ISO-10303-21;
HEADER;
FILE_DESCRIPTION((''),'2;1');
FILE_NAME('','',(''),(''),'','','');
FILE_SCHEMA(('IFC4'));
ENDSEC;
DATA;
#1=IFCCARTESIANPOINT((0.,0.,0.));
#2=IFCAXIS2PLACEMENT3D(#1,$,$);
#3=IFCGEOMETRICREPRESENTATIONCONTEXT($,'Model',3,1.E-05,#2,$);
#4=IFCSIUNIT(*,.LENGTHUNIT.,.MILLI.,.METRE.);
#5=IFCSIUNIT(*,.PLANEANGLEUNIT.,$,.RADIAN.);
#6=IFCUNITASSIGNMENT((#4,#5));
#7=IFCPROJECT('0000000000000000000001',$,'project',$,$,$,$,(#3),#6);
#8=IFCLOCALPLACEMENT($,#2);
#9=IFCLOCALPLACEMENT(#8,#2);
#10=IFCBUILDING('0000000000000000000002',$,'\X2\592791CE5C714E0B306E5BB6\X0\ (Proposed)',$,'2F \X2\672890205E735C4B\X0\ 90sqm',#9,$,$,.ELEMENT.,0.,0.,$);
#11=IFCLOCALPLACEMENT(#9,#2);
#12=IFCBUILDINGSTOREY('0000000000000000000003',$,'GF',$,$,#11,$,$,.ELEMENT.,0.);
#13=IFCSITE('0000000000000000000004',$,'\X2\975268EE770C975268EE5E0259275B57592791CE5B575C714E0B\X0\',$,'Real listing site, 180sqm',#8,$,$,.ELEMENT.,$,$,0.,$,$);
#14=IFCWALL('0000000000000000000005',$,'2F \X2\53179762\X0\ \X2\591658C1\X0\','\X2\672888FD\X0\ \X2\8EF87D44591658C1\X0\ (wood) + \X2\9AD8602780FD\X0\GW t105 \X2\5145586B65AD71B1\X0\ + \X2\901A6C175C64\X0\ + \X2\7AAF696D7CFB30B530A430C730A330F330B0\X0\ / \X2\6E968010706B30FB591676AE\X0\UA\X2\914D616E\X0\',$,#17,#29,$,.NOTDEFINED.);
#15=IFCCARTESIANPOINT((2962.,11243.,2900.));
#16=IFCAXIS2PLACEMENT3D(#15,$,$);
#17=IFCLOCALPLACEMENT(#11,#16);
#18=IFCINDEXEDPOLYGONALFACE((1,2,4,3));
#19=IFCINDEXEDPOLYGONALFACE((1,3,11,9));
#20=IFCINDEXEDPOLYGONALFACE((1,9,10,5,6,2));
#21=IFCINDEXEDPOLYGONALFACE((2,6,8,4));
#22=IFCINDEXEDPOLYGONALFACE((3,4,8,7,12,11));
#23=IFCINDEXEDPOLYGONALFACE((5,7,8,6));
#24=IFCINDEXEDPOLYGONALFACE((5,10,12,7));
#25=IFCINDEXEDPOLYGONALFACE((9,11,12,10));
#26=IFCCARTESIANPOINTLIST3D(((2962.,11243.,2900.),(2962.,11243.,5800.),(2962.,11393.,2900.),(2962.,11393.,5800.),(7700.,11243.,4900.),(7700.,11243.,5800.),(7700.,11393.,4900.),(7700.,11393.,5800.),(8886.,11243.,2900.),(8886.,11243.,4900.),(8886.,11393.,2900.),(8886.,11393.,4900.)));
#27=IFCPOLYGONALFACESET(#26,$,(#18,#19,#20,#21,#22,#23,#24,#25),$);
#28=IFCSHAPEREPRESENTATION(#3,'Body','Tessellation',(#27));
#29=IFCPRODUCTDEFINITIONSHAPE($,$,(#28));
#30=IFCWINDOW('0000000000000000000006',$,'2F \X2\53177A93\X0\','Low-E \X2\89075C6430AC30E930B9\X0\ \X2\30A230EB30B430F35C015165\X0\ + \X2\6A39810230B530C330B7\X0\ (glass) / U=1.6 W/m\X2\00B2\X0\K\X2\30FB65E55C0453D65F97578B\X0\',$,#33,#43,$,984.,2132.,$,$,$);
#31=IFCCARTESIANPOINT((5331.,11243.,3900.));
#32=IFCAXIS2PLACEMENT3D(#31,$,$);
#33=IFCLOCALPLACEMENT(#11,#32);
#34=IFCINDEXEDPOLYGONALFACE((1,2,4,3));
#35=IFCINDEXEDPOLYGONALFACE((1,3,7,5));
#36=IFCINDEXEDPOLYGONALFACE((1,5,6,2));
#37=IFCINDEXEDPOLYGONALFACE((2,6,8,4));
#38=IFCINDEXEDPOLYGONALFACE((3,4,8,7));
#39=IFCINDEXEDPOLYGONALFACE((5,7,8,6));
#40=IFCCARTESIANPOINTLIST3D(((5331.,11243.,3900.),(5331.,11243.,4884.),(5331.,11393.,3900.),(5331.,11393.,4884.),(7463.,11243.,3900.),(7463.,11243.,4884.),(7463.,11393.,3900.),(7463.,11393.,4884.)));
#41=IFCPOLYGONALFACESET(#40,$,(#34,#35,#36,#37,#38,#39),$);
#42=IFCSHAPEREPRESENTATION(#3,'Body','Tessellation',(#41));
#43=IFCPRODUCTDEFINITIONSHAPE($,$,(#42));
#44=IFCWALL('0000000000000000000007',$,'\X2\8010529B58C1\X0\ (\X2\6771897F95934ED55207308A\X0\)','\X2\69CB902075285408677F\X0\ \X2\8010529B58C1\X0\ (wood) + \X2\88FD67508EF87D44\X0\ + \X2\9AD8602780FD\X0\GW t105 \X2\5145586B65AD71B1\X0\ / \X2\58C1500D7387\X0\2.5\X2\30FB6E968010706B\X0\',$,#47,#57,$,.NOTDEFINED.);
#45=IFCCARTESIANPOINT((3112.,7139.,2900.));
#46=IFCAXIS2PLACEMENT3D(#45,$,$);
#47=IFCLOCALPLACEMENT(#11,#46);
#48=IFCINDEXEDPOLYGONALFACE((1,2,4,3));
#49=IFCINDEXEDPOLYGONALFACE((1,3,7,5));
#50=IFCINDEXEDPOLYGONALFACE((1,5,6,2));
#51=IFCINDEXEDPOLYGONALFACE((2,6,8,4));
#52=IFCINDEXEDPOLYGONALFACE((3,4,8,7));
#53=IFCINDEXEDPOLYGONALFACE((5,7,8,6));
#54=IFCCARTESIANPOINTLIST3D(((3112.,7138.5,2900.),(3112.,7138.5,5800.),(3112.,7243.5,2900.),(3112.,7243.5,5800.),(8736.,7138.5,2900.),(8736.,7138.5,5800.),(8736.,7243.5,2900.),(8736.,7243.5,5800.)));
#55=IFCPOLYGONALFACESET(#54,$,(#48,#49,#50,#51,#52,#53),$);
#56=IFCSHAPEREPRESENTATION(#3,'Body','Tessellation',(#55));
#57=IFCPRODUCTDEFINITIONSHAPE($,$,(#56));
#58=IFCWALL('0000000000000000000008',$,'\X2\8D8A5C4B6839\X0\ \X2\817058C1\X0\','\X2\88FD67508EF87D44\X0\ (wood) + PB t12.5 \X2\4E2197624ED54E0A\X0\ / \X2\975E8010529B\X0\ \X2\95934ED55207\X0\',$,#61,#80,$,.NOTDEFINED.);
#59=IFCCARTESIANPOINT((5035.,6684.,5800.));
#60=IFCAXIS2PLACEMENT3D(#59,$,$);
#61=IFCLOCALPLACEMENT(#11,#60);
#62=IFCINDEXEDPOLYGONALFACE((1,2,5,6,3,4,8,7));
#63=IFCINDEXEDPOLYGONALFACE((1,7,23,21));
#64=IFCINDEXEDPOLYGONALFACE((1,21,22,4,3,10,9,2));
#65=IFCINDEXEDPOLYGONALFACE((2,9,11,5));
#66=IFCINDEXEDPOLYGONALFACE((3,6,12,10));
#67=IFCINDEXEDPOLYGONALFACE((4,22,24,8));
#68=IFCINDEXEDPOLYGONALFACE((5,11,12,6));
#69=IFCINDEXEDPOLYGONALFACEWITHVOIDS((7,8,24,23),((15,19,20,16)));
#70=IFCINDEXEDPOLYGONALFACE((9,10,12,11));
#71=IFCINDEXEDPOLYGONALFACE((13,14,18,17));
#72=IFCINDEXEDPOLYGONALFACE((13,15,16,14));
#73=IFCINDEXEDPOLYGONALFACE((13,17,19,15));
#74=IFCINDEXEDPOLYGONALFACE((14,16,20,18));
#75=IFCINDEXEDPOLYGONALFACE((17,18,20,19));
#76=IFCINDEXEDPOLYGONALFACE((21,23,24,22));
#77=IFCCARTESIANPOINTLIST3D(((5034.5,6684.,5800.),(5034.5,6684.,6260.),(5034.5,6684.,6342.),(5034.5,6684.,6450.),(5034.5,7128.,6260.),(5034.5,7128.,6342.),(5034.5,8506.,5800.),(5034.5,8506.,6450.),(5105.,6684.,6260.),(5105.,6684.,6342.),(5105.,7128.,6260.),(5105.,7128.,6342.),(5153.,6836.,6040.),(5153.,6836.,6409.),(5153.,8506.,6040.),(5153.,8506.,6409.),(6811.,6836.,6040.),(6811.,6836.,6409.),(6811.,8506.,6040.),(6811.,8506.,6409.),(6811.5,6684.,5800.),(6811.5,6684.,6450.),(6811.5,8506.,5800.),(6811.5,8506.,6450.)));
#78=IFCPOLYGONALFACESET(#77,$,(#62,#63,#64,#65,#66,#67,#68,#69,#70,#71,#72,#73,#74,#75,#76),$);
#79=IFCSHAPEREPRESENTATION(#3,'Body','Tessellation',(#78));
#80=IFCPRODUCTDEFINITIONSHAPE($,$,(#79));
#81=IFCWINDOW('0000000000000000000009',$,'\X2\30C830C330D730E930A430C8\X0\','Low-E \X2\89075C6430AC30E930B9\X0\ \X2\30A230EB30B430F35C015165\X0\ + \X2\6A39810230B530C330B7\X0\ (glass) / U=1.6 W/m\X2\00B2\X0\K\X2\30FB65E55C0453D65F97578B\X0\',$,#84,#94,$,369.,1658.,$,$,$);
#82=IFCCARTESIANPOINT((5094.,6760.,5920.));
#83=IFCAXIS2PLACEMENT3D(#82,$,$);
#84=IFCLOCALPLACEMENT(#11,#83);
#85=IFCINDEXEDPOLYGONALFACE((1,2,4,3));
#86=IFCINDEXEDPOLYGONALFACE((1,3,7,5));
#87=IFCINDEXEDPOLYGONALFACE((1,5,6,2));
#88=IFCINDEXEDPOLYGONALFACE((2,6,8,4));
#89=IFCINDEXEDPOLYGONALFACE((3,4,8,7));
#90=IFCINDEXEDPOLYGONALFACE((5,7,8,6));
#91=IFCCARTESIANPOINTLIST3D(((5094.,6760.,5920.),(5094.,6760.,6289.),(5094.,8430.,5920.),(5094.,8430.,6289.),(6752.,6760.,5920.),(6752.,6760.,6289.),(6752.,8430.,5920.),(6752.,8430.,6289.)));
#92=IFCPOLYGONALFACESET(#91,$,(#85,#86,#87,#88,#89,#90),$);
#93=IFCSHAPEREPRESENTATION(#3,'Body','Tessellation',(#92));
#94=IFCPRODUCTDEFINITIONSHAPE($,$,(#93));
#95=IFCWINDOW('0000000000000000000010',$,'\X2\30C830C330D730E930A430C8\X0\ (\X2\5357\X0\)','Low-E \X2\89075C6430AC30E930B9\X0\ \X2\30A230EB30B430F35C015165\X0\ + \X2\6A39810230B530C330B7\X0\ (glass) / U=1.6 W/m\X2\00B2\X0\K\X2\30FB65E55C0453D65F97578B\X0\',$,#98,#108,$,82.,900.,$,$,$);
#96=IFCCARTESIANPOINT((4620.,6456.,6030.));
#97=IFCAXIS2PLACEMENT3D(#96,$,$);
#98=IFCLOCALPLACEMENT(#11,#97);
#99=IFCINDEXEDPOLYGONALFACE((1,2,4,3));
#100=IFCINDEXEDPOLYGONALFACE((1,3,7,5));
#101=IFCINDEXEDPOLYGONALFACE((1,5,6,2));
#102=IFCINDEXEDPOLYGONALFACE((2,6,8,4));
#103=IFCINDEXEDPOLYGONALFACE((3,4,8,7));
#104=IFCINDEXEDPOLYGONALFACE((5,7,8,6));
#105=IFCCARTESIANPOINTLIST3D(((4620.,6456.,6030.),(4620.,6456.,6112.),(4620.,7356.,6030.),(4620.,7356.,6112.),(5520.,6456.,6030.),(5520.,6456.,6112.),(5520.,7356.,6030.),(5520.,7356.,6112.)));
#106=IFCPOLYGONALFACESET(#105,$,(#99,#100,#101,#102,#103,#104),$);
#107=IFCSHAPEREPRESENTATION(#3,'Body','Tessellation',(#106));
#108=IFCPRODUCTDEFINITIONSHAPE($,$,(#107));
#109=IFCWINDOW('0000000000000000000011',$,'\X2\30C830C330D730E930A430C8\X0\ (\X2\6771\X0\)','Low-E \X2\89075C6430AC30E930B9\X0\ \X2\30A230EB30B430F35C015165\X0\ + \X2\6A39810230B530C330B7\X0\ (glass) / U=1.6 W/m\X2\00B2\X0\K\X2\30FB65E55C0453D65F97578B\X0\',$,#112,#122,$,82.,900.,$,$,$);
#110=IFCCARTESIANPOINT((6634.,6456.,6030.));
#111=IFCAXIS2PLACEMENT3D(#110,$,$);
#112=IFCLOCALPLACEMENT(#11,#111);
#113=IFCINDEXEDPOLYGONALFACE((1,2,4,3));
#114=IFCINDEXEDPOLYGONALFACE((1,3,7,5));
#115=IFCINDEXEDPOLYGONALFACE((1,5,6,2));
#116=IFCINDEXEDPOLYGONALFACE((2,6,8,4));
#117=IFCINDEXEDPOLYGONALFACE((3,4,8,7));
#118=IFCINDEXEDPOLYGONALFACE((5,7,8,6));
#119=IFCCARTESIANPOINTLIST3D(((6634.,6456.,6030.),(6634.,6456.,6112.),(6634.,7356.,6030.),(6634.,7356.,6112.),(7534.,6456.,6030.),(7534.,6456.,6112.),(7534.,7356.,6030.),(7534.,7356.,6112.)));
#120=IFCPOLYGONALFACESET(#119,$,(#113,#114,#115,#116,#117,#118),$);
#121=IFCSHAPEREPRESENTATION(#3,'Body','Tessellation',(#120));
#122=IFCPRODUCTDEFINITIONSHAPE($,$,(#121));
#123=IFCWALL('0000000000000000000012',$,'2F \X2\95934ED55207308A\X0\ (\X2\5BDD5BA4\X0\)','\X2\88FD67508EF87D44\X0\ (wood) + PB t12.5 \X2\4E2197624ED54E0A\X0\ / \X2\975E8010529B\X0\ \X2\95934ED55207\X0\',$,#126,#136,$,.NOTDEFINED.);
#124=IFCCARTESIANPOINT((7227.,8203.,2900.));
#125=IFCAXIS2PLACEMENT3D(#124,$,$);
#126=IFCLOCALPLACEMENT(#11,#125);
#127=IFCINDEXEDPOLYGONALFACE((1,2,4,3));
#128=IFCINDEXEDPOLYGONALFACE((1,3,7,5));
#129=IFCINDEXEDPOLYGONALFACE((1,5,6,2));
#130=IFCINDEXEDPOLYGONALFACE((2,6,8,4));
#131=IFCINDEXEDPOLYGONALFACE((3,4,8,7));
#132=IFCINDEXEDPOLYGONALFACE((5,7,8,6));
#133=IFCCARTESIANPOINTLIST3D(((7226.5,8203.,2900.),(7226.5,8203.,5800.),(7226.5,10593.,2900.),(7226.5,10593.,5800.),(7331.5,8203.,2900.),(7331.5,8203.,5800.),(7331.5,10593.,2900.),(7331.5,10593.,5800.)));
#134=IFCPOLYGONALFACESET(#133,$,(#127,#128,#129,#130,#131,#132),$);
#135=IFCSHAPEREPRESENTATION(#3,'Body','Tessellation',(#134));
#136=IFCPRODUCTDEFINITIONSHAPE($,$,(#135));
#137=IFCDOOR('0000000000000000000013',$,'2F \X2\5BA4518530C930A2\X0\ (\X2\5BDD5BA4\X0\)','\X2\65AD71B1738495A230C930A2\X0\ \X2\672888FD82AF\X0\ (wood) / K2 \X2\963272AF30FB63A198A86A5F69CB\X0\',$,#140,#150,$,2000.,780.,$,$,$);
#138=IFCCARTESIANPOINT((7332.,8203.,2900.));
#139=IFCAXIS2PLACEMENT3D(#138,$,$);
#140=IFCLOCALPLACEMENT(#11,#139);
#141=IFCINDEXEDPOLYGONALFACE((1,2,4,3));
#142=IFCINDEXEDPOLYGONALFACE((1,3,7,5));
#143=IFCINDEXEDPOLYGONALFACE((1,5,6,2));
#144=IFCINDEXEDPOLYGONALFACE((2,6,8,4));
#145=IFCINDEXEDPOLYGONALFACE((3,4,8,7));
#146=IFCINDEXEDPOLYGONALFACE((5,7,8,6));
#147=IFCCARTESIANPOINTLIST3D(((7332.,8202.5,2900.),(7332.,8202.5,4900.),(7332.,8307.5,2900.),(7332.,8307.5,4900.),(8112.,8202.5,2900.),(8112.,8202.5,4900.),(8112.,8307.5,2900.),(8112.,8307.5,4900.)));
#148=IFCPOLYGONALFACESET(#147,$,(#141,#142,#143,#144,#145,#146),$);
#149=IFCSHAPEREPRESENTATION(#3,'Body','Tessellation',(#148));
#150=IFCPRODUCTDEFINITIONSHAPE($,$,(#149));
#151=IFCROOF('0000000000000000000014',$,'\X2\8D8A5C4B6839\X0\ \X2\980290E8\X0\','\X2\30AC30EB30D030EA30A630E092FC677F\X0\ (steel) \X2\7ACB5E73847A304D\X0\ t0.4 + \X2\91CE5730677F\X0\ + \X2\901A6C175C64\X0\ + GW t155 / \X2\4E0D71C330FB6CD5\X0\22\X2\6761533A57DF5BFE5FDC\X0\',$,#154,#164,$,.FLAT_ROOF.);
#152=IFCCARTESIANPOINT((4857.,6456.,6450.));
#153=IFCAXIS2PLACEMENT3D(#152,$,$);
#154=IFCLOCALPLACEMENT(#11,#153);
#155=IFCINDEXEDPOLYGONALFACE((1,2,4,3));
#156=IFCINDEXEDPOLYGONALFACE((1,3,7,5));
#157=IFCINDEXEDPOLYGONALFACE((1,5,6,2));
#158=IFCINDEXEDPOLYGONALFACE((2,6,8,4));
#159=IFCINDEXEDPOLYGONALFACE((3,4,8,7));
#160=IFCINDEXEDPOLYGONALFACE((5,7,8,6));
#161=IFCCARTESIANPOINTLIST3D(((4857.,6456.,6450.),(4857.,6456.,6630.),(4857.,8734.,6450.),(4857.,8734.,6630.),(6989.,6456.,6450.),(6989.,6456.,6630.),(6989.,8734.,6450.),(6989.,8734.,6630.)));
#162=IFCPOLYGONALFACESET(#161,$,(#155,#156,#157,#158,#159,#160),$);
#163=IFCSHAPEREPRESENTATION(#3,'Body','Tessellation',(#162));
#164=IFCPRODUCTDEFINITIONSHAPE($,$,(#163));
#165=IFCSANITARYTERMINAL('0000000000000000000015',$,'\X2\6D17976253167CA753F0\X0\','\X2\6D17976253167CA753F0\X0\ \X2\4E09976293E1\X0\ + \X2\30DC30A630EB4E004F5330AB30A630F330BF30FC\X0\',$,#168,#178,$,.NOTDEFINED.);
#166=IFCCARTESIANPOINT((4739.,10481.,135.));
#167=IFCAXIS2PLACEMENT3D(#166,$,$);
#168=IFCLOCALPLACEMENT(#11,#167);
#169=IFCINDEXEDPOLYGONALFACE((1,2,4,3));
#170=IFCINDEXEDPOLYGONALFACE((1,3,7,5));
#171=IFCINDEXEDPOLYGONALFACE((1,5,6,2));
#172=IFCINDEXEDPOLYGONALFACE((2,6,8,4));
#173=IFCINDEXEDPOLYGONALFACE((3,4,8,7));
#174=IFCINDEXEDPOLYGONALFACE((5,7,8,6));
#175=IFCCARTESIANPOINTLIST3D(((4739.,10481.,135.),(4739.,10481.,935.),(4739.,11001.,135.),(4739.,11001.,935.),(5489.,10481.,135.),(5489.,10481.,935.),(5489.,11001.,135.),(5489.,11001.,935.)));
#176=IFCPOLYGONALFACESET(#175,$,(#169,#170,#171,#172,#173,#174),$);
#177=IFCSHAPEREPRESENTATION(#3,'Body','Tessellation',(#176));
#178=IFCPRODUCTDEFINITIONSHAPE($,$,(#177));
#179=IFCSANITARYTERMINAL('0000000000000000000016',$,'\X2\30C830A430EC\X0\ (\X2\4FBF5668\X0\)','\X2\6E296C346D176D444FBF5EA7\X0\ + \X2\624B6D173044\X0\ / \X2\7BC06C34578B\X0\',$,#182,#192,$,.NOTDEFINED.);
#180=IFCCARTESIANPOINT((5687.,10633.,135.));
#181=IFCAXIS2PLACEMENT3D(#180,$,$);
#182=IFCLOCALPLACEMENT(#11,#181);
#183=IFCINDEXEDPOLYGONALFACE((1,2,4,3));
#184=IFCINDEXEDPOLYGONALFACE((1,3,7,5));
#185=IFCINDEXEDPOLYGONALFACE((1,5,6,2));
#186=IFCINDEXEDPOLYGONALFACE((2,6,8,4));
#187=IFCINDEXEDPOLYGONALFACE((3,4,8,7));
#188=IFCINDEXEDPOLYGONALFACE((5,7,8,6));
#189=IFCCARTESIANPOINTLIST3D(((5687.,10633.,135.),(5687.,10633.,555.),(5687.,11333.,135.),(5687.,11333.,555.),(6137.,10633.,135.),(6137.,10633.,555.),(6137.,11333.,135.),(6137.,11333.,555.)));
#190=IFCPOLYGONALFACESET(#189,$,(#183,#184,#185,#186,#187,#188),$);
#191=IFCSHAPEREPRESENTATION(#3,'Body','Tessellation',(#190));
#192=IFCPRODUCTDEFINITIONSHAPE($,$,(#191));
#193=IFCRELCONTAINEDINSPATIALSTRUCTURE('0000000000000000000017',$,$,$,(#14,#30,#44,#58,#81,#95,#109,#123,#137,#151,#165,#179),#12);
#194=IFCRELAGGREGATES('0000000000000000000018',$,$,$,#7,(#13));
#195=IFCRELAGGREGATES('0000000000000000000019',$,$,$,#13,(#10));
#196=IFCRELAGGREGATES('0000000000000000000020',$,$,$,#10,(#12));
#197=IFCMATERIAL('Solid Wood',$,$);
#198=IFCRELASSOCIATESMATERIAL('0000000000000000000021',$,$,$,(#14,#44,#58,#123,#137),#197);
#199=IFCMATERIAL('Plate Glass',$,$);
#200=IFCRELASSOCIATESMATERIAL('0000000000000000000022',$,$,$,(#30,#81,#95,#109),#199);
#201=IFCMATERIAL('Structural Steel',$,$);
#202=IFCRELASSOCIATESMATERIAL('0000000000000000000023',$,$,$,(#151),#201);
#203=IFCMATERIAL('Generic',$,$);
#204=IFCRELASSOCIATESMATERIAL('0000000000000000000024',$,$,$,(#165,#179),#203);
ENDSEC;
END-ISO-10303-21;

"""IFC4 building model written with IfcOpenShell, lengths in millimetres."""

from ifc_helpers import new_model, si_unit, frame, frame_2d, origin, place, context, project, spatial, rectangle, extrude, material, element, fill, save


model = new_model("IFC4")

# Units and contexts
model_context = context("Model", 3, precision=1e-05, world=origin())
ifc_project = project(units=[si_unit("LENGTHUNIT", "METRE", prefix="MILLI"), si_unit("PLANEANGLEUNIT", "RADIAN")], contexts=[model_context])

# Site, building, storey
site_placement = place(None, origin())
site = spatial("IfcSite", under=ifc_project, at=site_placement, Name="青森県青森市大字大野字山下", ObjectType="Real listing site, 180sqm", CompositionType="ELEMENT", RefElevation=0.0)
building_placement = place(site_placement, origin())
building = spatial("IfcBuilding", under=site, at=building_placement, Name="大野山下の家 (Proposed)", ObjectType="2F 木造平屋 90sqm", CompositionType="ELEMENT", ElevationOfRefHeight=0.0, ElevationOfTerrain=0.0)
storey_placement = place(building_placement, origin())
storey = spatial("IfcBuildingStorey", under=building, at=storey_placement, Name="GF", CompositionType="ELEMENT", Elevation=0.0)

# Wall, opening, window
ifc_material_1 = material(Name="Solid Wood")
wall_1_placement = place(storey_placement, frame((2962.0, 11243.0, 2900.0)))
wall_1 = element("IfcWall", 1, at=wall_1_placement, inside=storey, material=ifc_material_1, Name="2F 北面 外壁", Description="木製 軸組外壁 (wood) + 高性能GW t105 充填断熱 + 通気層 + 窯業系サイディング / 準耐火・外皮UA配慮", PredefinedType="NOTDEFINED", context=model_context, shape_type="SweptSolid", body=[
    extrude(rectangle(XDim=5924.0, YDim=150.0, at=frame_2d((2962.0, 75.0))), frame((2962.0, 11243.0, 2900.0)), (0.0, 0.0, 1.0), 2900.0),
])
opening_1_placement = place(storey_placement, frame((5331.0, 11243.0, 3900.0)))
opening_1 = element("IfcOpeningElement", 2, at=opening_1_placement, cuts=wall_1, PredefinedType="NOTDEFINED", context=model_context, shape_type="SweptSolid", body=[
    extrude(rectangle(XDim=2132.0, YDim=150.0, at=frame_2d((1066.0, 75.0))), frame((5331.0, 11243.0, 3900.0)), (0.0, 0.0, 1.0), 984.0),
])
ifc_material_2 = material(Name="Plate Glass")
window_1_placement = place(storey_placement, frame((5331.0, 11243.0, 3900.0)))
window_1 = element("IfcWindow", 3, at=window_1_placement, inside=storey, material=ifc_material_2, Name="2F 北窓", Description="Low-E 複層ガラス アルゴン封入 + 樹脂サッシ (glass) / U=1.6 W/m²K・日射取得型", OverallHeight=984.0, OverallWidth=2132.0, context=model_context, shape_type="SweptSolid", body=[
    extrude(rectangle(XDim=2132.0, YDim=150.0, at=frame_2d((1066.0, 75.0))), frame((5331.0, 11243.0, 3900.0)), (0.0, 0.0, 1.0), 984.0),
])
fill(opening_1, window_1)

# Wall
wall_2_placement = place(storey_placement, frame((3112.0, 7139.0, 2900.0)))
element("IfcWall", 4, at=wall_2_placement, inside=storey, material=ifc_material_1, Name="耐力壁 (東西間仕切り)", Description="構造用合板 耐力壁 (wood) + 製材軸組 + 高性能GW t105 充填断熱 / 壁倍率2.5・準耐火", PredefinedType="NOTDEFINED", context=model_context, shape_type="SweptSolid", body=[
    extrude(rectangle(XDim=5624.0, YDim=105.0, at=frame_2d((2812.0, 52.0))), frame((3112.0, 7139.0, 2900.0)), (0.0, 0.0, 1.0), 2900.0),
])

# Wall, openings, windows
wall_3_placement = place(storey_placement, frame((5035.0, 6684.0, 5800.0)))
wall_3 = element("IfcWall", 5, at=wall_3_placement, inside=storey, material=ifc_material_1, Name="越屋根 腰壁", Description="製材軸組 (wood) + PB t12.5 両面仕上 / 非耐力 間仕切", PredefinedType="NOTDEFINED", context=model_context, shape_type="SweptSolid", body=[
    extrude(rectangle(XDim=1777.0, YDim=1822.0, at=frame_2d((888.0, 911.0))), frame((5035.0, 6684.0, 5800.0)), (0.0, 0.0, 1.0), 650.0),
])
opening_2_placement = place(storey_placement, frame((5094.0, 6760.0, 5920.0)))
opening_2 = element("IfcOpeningElement", 6, at=opening_2_placement, cuts=wall_3, PredefinedType="NOTDEFINED", context=model_context, shape_type="SweptSolid", body=[
    extrude(rectangle(XDim=1658.0, YDim=1670.0, at=frame_2d((829.0, 835.0))), frame((5094.0, 6760.0, 5920.0)), (0.0, 0.0, 1.0), 369.0),
])
opening_3_placement = place(storey_placement, frame((4620.0, 6456.0, 6030.0)))
opening_3 = element("IfcOpeningElement", 7, at=opening_3_placement, cuts=wall_3, PredefinedType="NOTDEFINED", context=model_context, shape_type="SweptSolid", body=[
    extrude(rectangle(XDim=900.0, YDim=900.0, at=frame_2d((450.0, 450.0))), frame((4620.0, 6456.0, 6030.0)), (0.0, 0.0, 1.0), 82.0),
])
opening_4_placement = place(storey_placement, frame((6634.0, 6456.0, 6030.0)))
opening_4 = element("IfcOpeningElement", 8, at=opening_4_placement, cuts=wall_3, PredefinedType="NOTDEFINED", context=model_context, shape_type="SweptSolid", body=[
    extrude(rectangle(XDim=900.0, YDim=900.0, at=frame_2d((450.0, 450.0))), frame((6634.0, 6456.0, 6030.0)), (0.0, 0.0, 1.0), 82.0),
])
window_2_placement = place(storey_placement, frame((5094.0, 6760.0, 5920.0)))
window_2 = element("IfcWindow", 9, at=window_2_placement, inside=storey, material=ifc_material_2, Name="トップライト", Description="Low-E 複層ガラス アルゴン封入 + 樹脂サッシ (glass) / U=1.6 W/m²K・日射取得型", OverallHeight=369.0, OverallWidth=1658.0, context=model_context, shape_type="SweptSolid", body=[
    extrude(rectangle(XDim=1658.0, YDim=1670.0, at=frame_2d((829.0, 835.0))), frame((5094.0, 6760.0, 5920.0)), (0.0, 0.0, 1.0), 369.0),
])
fill(opening_2, window_2)
window_3_placement = place(storey_placement, frame((4620.0, 6456.0, 6030.0)))
window_3 = element("IfcWindow", 10, at=window_3_placement, inside=storey, material=ifc_material_2, Name="トップライト (南)", Description="Low-E 複層ガラス アルゴン封入 + 樹脂サッシ (glass) / U=1.6 W/m²K・日射取得型", OverallHeight=82.0, OverallWidth=900.0, context=model_context, shape_type="SweptSolid", body=[
    extrude(rectangle(XDim=900.0, YDim=900.0, at=frame_2d((450.0, 450.0))), frame((4620.0, 6456.0, 6030.0)), (0.0, 0.0, 1.0), 82.0),
])
fill(opening_3, window_3)
window_4_placement = place(storey_placement, frame((6634.0, 6456.0, 6030.0)))
window_4 = element("IfcWindow", 11, at=window_4_placement, inside=storey, material=ifc_material_2, Name="トップライト (東)", Description="Low-E 複層ガラス アルゴン封入 + 樹脂サッシ (glass) / U=1.6 W/m²K・日射取得型", OverallHeight=82.0, OverallWidth=900.0, context=model_context, shape_type="SweptSolid", body=[
    extrude(rectangle(XDim=900.0, YDim=900.0, at=frame_2d((450.0, 450.0))), frame((6634.0, 6456.0, 6030.0)), (0.0, 0.0, 1.0), 82.0),
])
fill(opening_4, window_4)

# Wall
wall_4_placement = place(storey_placement, frame((7227.0, 8203.0, 2900.0)))
element("IfcWall", 12, at=wall_4_placement, inside=storey, material=ifc_material_1, Name="2F 間仕切り (寝室)", Description="製材軸組 (wood) + PB t12.5 両面仕上 / 非耐力 間仕切", PredefinedType="NOTDEFINED", context=model_context, shape_type="SweptSolid", body=[
    extrude(rectangle(XDim=105.0, YDim=2390.0, at=frame_2d((52.0, 1195.0))), frame((7227.0, 8203.0, 2900.0)), (0.0, 0.0, 1.0), 2900.0),
])

# Door
door_placement = place(storey_placement, frame((7332.0, 8203.0, 2900.0)))
element("IfcDoor", 13, at=door_placement, inside=storey, material=ifc_material_1, Name="2F 室内ドア (寝室)", Description="断熱玄関ドア 木製芯 (wood) / K2 防犯・採風機構", OverallHeight=2000.0, OverallWidth=780.0, context=model_context, shape_type="SweptSolid", body=[
    extrude(rectangle(XDim=780.0, YDim=105.0, at=frame_2d((390.0, 52.0))), frame((7332.0, 8203.0, 2900.0)), (0.0, 0.0, 1.0), 2000.0),
])

# Roof
ifc_material_3 = material(Name="Structural Steel")
roof_placement = place(storey_placement, frame((4857.0, 6456.0, 6450.0)))
element("IfcRoof", 14, at=roof_placement, inside=storey, material=ifc_material_3, Name="越屋根 頂部", Description="ガルバリウム鋼板 (steel) 立平葺き t0.4 + 野地板 + 通気層 + GW t155 / 不燃・法22条区域対応", PredefinedType="FLAT_ROOF", context=model_context, shape_type="SweptSolid", body=[
    extrude(rectangle(XDim=2132.0, YDim=2278.0, at=frame_2d((1066.0, 1139.0))), frame((4857.0, 6456.0, 6450.0)), (0.0, 0.0, 1.0), 180.0),
])

# Sanitary terminals
ifc_material_4 = material(Name="Generic")
sanitary_terminal_1_placement = place(storey_placement, frame((4739.0, 10481.0, 135.0)))
element("IfcSanitaryTerminal", 15, at=sanitary_terminal_1_placement, inside=storey, material=ifc_material_4, Name="洗面化粧台", Description="洗面化粧台 三面鏡 + ボウル一体カウンター", PredefinedType="NOTDEFINED", context=model_context, shape_type="SweptSolid", body=[
    extrude(rectangle(XDim=750.0, YDim=520.0, at=frame_2d((375.0, 260.0))), frame((4739.0, 10481.0, 135.0)), (0.0, 0.0, 1.0), 800.0),
])
sanitary_terminal_2_placement = place(storey_placement, frame((5687.0, 10633.0, 135.0)))
element("IfcSanitaryTerminal", 16, at=sanitary_terminal_2_placement, inside=storey, material=ifc_material_4, Name="トイレ (便器)", Description="温水洗浄便座 + 手洗い / 節水型", PredefinedType="NOTDEFINED", context=model_context, shape_type="SweptSolid", body=[
    extrude(rectangle(XDim=450.0, YDim=700.0, at=frame_2d((225.0, 350.0))), frame((5687.0, 10633.0, 135.0)), (0.0, 0.0, 1.0), 420.0),
])

save(model, "model.ifc")
